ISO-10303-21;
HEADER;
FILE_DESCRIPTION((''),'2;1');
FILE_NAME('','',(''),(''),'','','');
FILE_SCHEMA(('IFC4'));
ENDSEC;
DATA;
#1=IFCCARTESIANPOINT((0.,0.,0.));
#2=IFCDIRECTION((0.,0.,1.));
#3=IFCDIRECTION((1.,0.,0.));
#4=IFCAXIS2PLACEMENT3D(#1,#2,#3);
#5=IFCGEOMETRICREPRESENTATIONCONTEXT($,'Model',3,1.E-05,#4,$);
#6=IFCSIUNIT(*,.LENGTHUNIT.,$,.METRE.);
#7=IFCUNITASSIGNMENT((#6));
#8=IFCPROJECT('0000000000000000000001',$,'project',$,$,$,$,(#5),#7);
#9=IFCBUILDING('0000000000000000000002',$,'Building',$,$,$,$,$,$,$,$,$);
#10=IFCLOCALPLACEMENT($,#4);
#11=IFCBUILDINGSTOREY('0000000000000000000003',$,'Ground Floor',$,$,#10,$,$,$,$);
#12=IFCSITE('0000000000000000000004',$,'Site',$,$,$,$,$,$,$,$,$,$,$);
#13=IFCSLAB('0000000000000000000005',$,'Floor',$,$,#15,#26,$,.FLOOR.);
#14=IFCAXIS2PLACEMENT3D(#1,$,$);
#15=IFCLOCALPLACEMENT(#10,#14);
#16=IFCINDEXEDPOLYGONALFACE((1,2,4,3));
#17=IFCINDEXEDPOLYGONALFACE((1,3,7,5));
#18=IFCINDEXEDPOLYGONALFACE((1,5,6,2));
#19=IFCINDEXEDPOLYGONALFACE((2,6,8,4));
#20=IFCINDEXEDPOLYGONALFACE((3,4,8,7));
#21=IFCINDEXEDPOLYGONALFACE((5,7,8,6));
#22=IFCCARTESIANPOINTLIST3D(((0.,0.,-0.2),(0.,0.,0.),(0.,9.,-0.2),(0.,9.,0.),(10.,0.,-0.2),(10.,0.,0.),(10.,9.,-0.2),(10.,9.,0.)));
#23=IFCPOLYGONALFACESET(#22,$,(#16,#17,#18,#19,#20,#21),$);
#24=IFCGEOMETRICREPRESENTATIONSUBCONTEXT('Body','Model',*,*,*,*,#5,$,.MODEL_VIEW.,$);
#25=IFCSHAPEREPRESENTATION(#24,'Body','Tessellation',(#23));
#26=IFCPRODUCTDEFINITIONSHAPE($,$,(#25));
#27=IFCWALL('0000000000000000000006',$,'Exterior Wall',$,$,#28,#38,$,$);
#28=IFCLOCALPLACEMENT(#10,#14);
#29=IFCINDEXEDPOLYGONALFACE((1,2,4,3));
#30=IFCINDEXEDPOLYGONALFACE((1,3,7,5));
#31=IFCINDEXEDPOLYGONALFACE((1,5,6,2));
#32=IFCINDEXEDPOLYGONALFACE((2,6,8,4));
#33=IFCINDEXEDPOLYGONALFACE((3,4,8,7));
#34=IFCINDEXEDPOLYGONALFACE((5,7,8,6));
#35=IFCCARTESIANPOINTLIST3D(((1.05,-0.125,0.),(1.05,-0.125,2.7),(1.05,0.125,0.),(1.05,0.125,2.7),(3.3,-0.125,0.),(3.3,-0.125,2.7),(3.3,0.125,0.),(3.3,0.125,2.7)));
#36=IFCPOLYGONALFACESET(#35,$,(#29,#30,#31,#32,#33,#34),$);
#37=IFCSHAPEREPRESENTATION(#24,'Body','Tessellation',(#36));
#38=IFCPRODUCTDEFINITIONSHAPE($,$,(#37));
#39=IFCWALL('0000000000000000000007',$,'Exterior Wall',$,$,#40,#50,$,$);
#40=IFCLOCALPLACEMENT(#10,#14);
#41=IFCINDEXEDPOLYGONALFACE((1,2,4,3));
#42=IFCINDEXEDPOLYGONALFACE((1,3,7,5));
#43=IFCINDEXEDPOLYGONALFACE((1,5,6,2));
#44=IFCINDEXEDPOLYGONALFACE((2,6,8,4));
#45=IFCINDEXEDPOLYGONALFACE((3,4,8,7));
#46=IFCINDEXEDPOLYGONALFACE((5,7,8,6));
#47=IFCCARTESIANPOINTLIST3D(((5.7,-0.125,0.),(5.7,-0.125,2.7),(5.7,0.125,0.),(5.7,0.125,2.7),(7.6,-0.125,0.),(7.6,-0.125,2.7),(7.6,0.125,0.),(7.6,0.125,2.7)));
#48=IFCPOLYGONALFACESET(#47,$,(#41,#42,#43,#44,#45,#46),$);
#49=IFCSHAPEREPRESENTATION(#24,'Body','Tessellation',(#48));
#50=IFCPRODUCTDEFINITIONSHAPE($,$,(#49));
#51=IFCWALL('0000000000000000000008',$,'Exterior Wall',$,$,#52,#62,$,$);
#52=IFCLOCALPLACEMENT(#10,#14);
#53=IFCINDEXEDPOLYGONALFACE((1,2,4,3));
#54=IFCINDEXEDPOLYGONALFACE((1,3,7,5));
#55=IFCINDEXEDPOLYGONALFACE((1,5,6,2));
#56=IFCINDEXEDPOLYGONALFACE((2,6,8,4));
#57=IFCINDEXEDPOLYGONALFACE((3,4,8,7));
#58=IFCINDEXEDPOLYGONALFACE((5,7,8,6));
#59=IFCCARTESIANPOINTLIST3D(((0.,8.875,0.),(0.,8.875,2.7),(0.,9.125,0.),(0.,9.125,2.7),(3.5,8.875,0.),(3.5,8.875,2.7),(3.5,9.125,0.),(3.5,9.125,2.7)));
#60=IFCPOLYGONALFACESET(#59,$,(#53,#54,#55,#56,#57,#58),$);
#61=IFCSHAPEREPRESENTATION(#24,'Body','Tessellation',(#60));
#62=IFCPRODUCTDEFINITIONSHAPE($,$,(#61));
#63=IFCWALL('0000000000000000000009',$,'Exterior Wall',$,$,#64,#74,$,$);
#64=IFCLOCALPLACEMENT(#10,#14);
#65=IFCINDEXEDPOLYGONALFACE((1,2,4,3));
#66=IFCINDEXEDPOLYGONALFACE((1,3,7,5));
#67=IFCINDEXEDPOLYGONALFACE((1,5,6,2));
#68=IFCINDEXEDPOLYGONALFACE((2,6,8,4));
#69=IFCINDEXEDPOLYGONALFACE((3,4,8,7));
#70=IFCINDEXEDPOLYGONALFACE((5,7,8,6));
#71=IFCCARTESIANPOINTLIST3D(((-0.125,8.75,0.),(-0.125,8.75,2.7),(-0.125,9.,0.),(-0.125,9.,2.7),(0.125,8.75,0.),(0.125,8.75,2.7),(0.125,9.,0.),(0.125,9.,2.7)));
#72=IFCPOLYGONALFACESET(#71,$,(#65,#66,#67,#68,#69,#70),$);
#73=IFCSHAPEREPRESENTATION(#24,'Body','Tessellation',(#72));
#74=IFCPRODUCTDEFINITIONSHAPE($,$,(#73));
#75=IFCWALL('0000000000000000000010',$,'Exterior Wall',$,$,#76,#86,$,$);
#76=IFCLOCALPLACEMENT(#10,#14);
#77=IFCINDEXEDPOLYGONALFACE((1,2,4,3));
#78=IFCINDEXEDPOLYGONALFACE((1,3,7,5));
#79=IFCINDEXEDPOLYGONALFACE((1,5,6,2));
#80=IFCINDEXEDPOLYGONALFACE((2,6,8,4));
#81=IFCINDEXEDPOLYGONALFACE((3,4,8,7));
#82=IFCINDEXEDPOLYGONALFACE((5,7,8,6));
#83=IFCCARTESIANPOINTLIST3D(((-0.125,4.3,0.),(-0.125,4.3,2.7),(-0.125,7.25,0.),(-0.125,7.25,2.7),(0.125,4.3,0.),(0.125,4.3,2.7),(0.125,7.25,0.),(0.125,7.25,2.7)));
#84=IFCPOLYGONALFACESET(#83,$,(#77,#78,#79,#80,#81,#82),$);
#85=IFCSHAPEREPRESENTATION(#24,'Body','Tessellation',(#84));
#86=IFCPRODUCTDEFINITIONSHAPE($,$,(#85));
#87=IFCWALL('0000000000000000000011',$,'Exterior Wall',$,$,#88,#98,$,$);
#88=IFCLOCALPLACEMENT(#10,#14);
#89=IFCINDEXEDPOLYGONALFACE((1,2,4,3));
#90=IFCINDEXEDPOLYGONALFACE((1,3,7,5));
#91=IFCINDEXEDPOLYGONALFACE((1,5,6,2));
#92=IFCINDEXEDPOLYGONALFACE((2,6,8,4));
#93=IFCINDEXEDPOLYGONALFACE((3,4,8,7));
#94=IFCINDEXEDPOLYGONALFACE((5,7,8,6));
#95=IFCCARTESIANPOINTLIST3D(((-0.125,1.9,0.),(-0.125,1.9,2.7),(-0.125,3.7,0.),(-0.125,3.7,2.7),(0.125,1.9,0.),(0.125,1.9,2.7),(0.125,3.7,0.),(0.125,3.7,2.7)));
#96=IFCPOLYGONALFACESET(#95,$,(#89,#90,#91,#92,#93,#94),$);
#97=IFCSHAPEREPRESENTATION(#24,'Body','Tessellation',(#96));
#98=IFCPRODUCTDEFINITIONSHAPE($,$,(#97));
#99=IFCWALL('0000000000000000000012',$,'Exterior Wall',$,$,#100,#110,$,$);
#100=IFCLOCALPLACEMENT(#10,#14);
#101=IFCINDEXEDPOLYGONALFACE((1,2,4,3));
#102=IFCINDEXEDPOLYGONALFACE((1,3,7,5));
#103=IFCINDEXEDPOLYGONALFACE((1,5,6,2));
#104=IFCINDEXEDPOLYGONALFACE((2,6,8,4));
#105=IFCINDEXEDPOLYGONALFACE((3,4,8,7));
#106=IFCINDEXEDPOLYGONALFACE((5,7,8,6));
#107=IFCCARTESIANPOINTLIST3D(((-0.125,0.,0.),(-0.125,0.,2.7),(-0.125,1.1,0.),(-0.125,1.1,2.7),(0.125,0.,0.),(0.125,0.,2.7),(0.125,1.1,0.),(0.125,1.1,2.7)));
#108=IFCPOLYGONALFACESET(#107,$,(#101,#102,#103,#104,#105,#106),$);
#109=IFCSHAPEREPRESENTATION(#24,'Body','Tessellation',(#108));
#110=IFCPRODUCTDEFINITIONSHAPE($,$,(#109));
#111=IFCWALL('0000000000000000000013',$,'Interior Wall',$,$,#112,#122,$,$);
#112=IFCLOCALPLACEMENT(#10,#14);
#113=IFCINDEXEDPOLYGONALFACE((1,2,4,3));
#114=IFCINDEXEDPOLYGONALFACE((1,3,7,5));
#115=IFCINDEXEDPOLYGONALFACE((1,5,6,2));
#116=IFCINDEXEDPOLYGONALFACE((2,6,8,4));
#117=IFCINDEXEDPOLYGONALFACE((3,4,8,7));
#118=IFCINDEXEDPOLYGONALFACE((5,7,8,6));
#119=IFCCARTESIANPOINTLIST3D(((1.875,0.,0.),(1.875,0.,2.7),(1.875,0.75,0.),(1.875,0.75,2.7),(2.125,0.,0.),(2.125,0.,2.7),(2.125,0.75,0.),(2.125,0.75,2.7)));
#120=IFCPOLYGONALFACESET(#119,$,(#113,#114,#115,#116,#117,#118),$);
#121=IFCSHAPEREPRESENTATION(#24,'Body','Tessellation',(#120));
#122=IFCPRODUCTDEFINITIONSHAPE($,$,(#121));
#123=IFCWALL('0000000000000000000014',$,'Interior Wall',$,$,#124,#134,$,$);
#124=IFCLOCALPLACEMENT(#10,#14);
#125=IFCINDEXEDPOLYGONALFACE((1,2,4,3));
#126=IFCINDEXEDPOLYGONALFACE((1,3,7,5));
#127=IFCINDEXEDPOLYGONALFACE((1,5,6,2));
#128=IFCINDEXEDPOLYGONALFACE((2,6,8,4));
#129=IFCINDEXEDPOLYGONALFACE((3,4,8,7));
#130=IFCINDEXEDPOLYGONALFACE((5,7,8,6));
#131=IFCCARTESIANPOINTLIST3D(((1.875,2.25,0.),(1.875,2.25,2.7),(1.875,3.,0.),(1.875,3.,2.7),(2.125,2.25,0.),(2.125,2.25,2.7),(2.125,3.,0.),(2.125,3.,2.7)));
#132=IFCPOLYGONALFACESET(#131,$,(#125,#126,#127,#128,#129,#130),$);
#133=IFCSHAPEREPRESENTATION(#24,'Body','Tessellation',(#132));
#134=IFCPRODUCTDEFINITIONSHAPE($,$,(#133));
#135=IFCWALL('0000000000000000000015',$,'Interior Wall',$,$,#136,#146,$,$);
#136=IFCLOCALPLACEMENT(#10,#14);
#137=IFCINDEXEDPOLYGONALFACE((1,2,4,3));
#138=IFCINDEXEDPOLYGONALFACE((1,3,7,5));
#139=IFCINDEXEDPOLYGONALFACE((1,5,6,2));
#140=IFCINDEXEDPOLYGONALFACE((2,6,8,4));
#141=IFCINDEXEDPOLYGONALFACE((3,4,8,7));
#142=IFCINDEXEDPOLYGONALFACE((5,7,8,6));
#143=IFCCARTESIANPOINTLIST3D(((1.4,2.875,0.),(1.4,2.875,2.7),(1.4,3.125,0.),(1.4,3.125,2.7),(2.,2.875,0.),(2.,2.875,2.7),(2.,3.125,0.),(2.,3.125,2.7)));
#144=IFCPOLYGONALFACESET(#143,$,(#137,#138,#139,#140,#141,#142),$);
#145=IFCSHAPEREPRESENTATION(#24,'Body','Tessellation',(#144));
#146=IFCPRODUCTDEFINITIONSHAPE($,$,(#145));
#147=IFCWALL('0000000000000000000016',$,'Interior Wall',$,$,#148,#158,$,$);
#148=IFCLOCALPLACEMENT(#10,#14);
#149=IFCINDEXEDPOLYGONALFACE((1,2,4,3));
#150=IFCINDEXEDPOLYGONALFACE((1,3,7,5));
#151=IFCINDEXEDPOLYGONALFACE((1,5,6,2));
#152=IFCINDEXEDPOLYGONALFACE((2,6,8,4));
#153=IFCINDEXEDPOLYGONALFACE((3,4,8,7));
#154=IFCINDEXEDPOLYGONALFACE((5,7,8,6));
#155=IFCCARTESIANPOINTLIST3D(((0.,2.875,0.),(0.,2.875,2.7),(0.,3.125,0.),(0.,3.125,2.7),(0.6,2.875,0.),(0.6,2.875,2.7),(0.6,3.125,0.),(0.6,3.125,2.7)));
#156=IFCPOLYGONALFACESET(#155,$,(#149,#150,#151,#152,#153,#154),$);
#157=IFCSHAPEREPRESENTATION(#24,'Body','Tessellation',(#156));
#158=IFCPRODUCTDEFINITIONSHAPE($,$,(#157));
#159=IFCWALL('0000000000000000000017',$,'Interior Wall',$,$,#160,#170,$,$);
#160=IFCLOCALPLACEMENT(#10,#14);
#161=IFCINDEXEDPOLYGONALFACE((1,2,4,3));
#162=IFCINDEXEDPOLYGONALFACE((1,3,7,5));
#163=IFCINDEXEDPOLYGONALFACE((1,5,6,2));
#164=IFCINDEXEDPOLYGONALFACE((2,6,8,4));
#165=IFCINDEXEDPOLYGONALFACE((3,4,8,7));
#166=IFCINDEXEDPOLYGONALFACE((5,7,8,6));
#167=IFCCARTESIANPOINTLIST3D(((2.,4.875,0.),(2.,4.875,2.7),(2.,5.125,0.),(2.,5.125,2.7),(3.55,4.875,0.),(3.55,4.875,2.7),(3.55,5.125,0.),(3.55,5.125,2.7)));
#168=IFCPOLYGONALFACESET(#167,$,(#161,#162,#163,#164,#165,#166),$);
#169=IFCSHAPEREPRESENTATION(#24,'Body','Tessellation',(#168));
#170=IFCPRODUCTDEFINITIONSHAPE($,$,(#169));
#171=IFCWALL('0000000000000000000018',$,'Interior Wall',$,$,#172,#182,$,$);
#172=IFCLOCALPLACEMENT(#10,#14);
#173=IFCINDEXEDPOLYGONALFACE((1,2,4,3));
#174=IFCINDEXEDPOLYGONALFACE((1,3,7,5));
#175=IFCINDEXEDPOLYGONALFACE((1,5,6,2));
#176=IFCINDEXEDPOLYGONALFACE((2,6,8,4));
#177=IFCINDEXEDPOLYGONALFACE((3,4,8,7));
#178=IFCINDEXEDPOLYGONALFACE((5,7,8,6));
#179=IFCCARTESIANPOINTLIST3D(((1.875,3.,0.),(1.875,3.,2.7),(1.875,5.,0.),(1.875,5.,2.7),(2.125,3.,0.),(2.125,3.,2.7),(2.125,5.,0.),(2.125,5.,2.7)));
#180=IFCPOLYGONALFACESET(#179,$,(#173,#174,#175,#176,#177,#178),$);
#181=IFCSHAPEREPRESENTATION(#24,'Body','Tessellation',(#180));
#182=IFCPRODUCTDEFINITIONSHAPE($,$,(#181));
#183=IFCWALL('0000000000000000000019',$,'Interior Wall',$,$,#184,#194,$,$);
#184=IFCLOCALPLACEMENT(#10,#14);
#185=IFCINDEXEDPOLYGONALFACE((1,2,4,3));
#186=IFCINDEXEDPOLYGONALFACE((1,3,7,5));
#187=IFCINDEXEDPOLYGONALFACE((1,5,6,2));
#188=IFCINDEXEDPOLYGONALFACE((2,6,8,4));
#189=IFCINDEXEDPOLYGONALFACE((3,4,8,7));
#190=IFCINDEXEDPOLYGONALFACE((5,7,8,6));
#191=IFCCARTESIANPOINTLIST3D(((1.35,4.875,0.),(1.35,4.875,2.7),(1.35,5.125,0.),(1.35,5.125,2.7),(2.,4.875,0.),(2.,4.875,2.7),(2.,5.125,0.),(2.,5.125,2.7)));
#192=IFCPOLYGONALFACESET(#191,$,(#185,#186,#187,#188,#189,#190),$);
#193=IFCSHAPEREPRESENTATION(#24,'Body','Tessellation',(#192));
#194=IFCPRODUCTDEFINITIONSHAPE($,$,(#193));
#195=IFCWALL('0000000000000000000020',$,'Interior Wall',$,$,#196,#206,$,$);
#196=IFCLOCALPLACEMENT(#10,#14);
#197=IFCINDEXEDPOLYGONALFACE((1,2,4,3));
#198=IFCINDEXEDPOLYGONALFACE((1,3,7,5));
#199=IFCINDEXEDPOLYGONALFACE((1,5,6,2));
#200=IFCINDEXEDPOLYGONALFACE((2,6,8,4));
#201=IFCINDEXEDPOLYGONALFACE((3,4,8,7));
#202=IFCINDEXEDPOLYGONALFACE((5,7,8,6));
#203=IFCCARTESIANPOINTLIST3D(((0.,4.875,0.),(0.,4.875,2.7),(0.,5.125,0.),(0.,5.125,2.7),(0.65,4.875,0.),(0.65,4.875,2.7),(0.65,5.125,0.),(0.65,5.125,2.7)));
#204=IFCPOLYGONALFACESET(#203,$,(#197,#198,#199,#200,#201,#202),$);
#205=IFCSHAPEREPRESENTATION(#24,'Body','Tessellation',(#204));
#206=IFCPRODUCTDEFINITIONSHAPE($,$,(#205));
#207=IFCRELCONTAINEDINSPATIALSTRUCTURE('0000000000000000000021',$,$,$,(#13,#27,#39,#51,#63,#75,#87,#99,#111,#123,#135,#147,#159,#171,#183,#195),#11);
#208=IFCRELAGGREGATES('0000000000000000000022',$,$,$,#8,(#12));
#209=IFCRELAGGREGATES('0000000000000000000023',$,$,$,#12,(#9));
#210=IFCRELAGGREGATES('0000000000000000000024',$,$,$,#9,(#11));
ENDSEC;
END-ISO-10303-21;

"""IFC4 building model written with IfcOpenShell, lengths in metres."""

from ifc_helpers import new_model, si_unit, frame, origin_with_axes, place, context, subcontext, project, spatial, indexed_curve, outline, extrude, element, save


model = new_model("IFC4")

# Units and contexts
model_context = context("Model", 3, precision=1e-05, world=origin_with_axes())
body_context = subcontext(model_context, "Body", "Model", "MODEL_VIEW")
ifc_project = project(units=[si_unit("LENGTHUNIT", "METRE")], contexts=[model_context])

# Site, building, storey
site = spatial("IfcSite", under=ifc_project, Name="Site")
building = spatial("IfcBuilding", under=site, Name="Building")
storey_placement = place(None, origin_with_axes())
storey = spatial("IfcBuildingStorey", under=building, at=storey_placement, Name="Ground Floor")

# Slab
slab_placement = place(storey_placement, frame((0.0, 0.0, -0.2), z_axis=(0.0, 0.0, 1.0), x_axis=(1.0, 0.0, 0.0)))
element("IfcSlab", 1, at=slab_placement, inside=storey, Name="Floor", PredefinedType="FLOOR", context=body_context, shape_type="SweptSolid", body=[
    extrude(outline(indexed_curve([(0.0, 0.0), (10.0, 0.0), (10.0, 9.0), (0.0, 9.0)])), None, (0.0, 0.0, 1.0), 0.2),
])

# Walls
wall_1_placement = place(storey_placement, frame((1.05, 0.0, 0.0), z_axis=(0.0, 0.0, 1.0), x_axis=(1.0, 0.0, 0.0)))
element("IfcWall", 2, at=wall_1_placement, inside=storey, Name="Exterior Wall", context=body_context, shape_type="SweptSolid", body=[
    extrude(outline(indexed_curve([(0.0, 0.0), (0.0, 0.25), (2.25, 0.25), (2.25, 0.0), (0.0, 0.0)], self_intersect=False)), frame((0.0, -0.125, 0.0), z_axis=(0.0, 0.0, 1.0), x_axis=(1.0, 0.0, 0.0)), (0.0, 0.0, 1.0), 2.7),
])
wall_2_placement = place(storey_placement, frame((5.7, 0.0, 0.0), z_axis=(0.0, 0.0, 1.0), x_axis=(1.0, 0.0, 0.0)))
element("IfcWall", 3, at=wall_2_placement, inside=storey, Name="Exterior Wall", context=body_context, shape_type="SweptSolid", body=[
    extrude(outline(indexed_curve([(0.0, 0.0), (0.0, 0.25), (1.9, 0.25), (1.9, 0.0), (0.0, 0.0)], self_intersect=False)), frame((0.0, -0.125, 0.0), z_axis=(0.0, 0.0, 1.0), x_axis=(1.0, 0.0, 0.0)), (0.0, 0.0, 1.0), 2.7),
])
wall_3_placement = place(storey_placement, frame((3.5, 9.0, 0.0), z_axis=(0.0, 0.0, 1.0), x_axis=(-1.0, 0.0, 0.0)))
element("IfcWall", 4, at=wall_3_placement, inside=storey, Name="Exterior Wall", context=body_context, shape_type="SweptSolid", body=[
    extrude(outline(indexed_curve([(0.0, 0.0), (0.0, 0.25), (3.5, 0.25), (3.5, 0.0), (0.0, 0.0)], self_intersect=False)), frame((0.0, -0.125, 0.0), z_axis=(0.0, 0.0, 1.0), x_axis=(1.0, 0.0, 0.0)), (0.0, 0.0, 1.0), 2.7),
])
wall_4_placement = place(storey_placement, frame((0.0, 9.0, 0.0), z_axis=(0.0, 0.0, 1.0), x_axis=(0.0, -1.0, 0.0)))
element("IfcWall", 5, at=wall_4_placement, inside=storey, Name="Exterior Wall", context=body_context, shape_type="SweptSolid", body=[
    extrude(outline(indexed_curve([(0.0, 0.0), (0.0, 0.25), (0.25, 0.25), (0.25, 0.0), (0.0, 0.0)], self_intersect=False)), frame((0.0, -0.125, 0.0), z_axis=(0.0, 0.0, 1.0), x_axis=(1.0, 0.0, 0.0)), (0.0, 0.0, 1.0), 2.7),
])
wall_5_placement = place(storey_placement, frame((0.0, 7.25, 0.0), z_axis=(0.0, 0.0, 1.0), x_axis=(0.0, -1.0, 0.0)))
element("IfcWall", 6, at=wall_5_placement, inside=storey, Name="Exterior Wall", context=body_context, shape_type="SweptSolid", body=[
    extrude(outline(indexed_curve([(0.0, 0.0), (0.0, 0.25), (2.95, 0.25), (2.95, 0.0), (0.0, 0.0)], self_intersect=False)), frame((0.0, -0.125, 0.0), z_axis=(0.0, 0.0, 1.0), x_axis=(1.0, 0.0, 0.0)), (0.0, 0.0, 1.0), 2.7),
])
wall_6_placement = place(storey_placement, frame((0.0, 3.7, 0.0), z_axis=(0.0, 0.0, 1.0), x_axis=(0.0, -1.0, 0.0)))
element("IfcWall", 7, at=wall_6_placement, inside=storey, Name="Exterior Wall", context=body_context, shape_type="SweptSolid", body=[
    extrude(outline(indexed_curve([(0.0, 0.0), (0.0, 0.25), (1.8, 0.25), (1.8, 0.0), (0.0, 0.0)], self_intersect=False)), frame((0.0, -0.125, 0.0), z_axis=(0.0, 0.0, 1.0), x_axis=(1.0, 0.0, 0.0)), (0.0, 0.0, 1.0), 2.7),
])
wall_7_placement = place(storey_placement, frame((0.0, 1.1, 0.0), z_axis=(0.0, 0.0, 1.0), x_axis=(0.0, -1.0, 0.0)))
element("IfcWall", 8, at=wall_7_placement, inside=storey, Name="Exterior Wall", context=body_context, shape_type="SweptSolid", body=[
    extrude(outline(indexed_curve([(0.0, 0.0), (0.0, 0.25), (1.1, 0.25), (1.1, 0.0), (0.0, 0.0)], self_intersect=False)), frame((0.0, -0.125, 0.0), z_axis=(0.0, 0.0, 1.0), x_axis=(1.0, 0.0, 0.0)), (0.0, 0.0, 1.0), 2.7),
])
for number, where, z_axis, x_axis, name in (
    (9, (2.0, 0.0, 0.0), (0.0, 0.0, 1.0), (0.0, 1.0, 0.0), "Interior Wall"),
    (10, (2.0, 2.25, 0.0), (0.0, 0.0, 1.0), (0.0, 1.0, 0.0), "Interior Wall"),
):
    element("IfcWall", number, at=place(storey_placement, frame(where, z_axis=z_axis, x_axis=x_axis)), inside=storey, Name=name, context=body_context, shape_type="SweptSolid", body=[
        extrude(outline(indexed_curve([(0.0, 0.0), (0.0, 0.25), (0.75, 0.25), (0.75, 0.0), (0.0, 0.0)], self_intersect=False)), frame((0.0, -0.125, 0.0), z_axis=(0.0, 0.0, 1.0), x_axis=(1.0, 0.0, 0.0)), (0.0, 0.0, 1.0), 2.7),
    ])
for number, where, z_axis, x_axis, name in (
    (11, (2.0, 3.0, 0.0), (0.0, 0.0, 1.0), (-1.0, 0.0, 0.0), "Interior Wall"),
    (12, (0.6, 3.0, 0.0), (0.0, 0.0, 1.0), (-1.0, 0.0, 0.0), "Interior Wall"),
):
    element("IfcWall", number, at=place(storey_placement, frame(where, z_axis=z_axis, x_axis=x_axis)), inside=storey, Name=name, context=body_context, shape_type="SweptSolid", body=[
        extrude(outline(indexed_curve([(0.0, 0.0), (0.0, 0.25), (0.6, 0.25), (0.6, 0.0), (0.0, 0.0)], self_intersect=False)), frame((0.0, -0.125, 0.0), z_axis=(0.0, 0.0, 1.0), x_axis=(1.0, 0.0, 0.0)), (0.0, 0.0, 1.0), 2.7),
    ])
wall_8_placement = place(storey_placement, frame((3.55, 5.0, 0.0), z_axis=(0.0, 0.0, 1.0), x_axis=(-1.0, 0.0, 0.0)))
element("IfcWall", 13, at=wall_8_placement, inside=storey, Name="Interior Wall", context=body_context, shape_type="SweptSolid", body=[
    extrude(outline(indexed_curve([(0.0, 0.0), (0.0, 0.25), (1.55, 0.25), (1.55, 0.0), (0.0, 0.0)], self_intersect=False)), frame((0.0, -0.125, 0.0), z_axis=(0.0, 0.0, 1.0), x_axis=(1.0, 0.0, 0.0)), (0.0, 0.0, 1.0), 2.7),
])
wall_9_placement = place(storey_placement, frame((2.0, 5.0, 0.0), z_axis=(0.0, 0.0, 1.0), x_axis=(0.0, -1.0, 0.0)))
element("IfcWall", 14, at=wall_9_placement, inside=storey, Name="Interior Wall", context=body_context, shape_type="SweptSolid", body=[
    extrude(outline(indexed_curve([(0.0, 0.0), (0.0, 0.25), (2.0, 0.25), (2.0, 0.0), (0.0, 0.0)], self_intersect=False)), frame((0.0, -0.125, 0.0), z_axis=(0.0, 0.0, 1.0), x_axis=(1.0, 0.0, 0.0)), (0.0, 0.0, 1.0), 2.7),
])
for number, where, z_axis, x_axis, name in (
    (15, (2.0, 5.0, 0.0), (0.0, 0.0, 1.0), (-1.0, 0.0, 0.0), "Interior Wall"),
    (16, (0.65, 5.0, 0.0), (0.0, 0.0, 1.0), (-1.0, 0.0, 0.0), "Interior Wall"),
):
    element("IfcWall", number, at=place(storey_placement, frame(where, z_axis=z_axis, x_axis=x_axis)), inside=storey, Name=name, context=body_context, shape_type="SweptSolid", body=[
        extrude(outline(indexed_curve([(0.0, 0.0), (0.0, 0.25), (0.65, 0.25), (0.65, 0.0), (0.0, 0.0)], self_intersect=False)), frame((0.0, -0.125, 0.0), z_axis=(0.0, 0.0, 1.0), x_axis=(1.0, 0.0, 0.0)), (0.0, 0.0, 1.0), 2.7),
    ])

save(model, "model.ifc")
